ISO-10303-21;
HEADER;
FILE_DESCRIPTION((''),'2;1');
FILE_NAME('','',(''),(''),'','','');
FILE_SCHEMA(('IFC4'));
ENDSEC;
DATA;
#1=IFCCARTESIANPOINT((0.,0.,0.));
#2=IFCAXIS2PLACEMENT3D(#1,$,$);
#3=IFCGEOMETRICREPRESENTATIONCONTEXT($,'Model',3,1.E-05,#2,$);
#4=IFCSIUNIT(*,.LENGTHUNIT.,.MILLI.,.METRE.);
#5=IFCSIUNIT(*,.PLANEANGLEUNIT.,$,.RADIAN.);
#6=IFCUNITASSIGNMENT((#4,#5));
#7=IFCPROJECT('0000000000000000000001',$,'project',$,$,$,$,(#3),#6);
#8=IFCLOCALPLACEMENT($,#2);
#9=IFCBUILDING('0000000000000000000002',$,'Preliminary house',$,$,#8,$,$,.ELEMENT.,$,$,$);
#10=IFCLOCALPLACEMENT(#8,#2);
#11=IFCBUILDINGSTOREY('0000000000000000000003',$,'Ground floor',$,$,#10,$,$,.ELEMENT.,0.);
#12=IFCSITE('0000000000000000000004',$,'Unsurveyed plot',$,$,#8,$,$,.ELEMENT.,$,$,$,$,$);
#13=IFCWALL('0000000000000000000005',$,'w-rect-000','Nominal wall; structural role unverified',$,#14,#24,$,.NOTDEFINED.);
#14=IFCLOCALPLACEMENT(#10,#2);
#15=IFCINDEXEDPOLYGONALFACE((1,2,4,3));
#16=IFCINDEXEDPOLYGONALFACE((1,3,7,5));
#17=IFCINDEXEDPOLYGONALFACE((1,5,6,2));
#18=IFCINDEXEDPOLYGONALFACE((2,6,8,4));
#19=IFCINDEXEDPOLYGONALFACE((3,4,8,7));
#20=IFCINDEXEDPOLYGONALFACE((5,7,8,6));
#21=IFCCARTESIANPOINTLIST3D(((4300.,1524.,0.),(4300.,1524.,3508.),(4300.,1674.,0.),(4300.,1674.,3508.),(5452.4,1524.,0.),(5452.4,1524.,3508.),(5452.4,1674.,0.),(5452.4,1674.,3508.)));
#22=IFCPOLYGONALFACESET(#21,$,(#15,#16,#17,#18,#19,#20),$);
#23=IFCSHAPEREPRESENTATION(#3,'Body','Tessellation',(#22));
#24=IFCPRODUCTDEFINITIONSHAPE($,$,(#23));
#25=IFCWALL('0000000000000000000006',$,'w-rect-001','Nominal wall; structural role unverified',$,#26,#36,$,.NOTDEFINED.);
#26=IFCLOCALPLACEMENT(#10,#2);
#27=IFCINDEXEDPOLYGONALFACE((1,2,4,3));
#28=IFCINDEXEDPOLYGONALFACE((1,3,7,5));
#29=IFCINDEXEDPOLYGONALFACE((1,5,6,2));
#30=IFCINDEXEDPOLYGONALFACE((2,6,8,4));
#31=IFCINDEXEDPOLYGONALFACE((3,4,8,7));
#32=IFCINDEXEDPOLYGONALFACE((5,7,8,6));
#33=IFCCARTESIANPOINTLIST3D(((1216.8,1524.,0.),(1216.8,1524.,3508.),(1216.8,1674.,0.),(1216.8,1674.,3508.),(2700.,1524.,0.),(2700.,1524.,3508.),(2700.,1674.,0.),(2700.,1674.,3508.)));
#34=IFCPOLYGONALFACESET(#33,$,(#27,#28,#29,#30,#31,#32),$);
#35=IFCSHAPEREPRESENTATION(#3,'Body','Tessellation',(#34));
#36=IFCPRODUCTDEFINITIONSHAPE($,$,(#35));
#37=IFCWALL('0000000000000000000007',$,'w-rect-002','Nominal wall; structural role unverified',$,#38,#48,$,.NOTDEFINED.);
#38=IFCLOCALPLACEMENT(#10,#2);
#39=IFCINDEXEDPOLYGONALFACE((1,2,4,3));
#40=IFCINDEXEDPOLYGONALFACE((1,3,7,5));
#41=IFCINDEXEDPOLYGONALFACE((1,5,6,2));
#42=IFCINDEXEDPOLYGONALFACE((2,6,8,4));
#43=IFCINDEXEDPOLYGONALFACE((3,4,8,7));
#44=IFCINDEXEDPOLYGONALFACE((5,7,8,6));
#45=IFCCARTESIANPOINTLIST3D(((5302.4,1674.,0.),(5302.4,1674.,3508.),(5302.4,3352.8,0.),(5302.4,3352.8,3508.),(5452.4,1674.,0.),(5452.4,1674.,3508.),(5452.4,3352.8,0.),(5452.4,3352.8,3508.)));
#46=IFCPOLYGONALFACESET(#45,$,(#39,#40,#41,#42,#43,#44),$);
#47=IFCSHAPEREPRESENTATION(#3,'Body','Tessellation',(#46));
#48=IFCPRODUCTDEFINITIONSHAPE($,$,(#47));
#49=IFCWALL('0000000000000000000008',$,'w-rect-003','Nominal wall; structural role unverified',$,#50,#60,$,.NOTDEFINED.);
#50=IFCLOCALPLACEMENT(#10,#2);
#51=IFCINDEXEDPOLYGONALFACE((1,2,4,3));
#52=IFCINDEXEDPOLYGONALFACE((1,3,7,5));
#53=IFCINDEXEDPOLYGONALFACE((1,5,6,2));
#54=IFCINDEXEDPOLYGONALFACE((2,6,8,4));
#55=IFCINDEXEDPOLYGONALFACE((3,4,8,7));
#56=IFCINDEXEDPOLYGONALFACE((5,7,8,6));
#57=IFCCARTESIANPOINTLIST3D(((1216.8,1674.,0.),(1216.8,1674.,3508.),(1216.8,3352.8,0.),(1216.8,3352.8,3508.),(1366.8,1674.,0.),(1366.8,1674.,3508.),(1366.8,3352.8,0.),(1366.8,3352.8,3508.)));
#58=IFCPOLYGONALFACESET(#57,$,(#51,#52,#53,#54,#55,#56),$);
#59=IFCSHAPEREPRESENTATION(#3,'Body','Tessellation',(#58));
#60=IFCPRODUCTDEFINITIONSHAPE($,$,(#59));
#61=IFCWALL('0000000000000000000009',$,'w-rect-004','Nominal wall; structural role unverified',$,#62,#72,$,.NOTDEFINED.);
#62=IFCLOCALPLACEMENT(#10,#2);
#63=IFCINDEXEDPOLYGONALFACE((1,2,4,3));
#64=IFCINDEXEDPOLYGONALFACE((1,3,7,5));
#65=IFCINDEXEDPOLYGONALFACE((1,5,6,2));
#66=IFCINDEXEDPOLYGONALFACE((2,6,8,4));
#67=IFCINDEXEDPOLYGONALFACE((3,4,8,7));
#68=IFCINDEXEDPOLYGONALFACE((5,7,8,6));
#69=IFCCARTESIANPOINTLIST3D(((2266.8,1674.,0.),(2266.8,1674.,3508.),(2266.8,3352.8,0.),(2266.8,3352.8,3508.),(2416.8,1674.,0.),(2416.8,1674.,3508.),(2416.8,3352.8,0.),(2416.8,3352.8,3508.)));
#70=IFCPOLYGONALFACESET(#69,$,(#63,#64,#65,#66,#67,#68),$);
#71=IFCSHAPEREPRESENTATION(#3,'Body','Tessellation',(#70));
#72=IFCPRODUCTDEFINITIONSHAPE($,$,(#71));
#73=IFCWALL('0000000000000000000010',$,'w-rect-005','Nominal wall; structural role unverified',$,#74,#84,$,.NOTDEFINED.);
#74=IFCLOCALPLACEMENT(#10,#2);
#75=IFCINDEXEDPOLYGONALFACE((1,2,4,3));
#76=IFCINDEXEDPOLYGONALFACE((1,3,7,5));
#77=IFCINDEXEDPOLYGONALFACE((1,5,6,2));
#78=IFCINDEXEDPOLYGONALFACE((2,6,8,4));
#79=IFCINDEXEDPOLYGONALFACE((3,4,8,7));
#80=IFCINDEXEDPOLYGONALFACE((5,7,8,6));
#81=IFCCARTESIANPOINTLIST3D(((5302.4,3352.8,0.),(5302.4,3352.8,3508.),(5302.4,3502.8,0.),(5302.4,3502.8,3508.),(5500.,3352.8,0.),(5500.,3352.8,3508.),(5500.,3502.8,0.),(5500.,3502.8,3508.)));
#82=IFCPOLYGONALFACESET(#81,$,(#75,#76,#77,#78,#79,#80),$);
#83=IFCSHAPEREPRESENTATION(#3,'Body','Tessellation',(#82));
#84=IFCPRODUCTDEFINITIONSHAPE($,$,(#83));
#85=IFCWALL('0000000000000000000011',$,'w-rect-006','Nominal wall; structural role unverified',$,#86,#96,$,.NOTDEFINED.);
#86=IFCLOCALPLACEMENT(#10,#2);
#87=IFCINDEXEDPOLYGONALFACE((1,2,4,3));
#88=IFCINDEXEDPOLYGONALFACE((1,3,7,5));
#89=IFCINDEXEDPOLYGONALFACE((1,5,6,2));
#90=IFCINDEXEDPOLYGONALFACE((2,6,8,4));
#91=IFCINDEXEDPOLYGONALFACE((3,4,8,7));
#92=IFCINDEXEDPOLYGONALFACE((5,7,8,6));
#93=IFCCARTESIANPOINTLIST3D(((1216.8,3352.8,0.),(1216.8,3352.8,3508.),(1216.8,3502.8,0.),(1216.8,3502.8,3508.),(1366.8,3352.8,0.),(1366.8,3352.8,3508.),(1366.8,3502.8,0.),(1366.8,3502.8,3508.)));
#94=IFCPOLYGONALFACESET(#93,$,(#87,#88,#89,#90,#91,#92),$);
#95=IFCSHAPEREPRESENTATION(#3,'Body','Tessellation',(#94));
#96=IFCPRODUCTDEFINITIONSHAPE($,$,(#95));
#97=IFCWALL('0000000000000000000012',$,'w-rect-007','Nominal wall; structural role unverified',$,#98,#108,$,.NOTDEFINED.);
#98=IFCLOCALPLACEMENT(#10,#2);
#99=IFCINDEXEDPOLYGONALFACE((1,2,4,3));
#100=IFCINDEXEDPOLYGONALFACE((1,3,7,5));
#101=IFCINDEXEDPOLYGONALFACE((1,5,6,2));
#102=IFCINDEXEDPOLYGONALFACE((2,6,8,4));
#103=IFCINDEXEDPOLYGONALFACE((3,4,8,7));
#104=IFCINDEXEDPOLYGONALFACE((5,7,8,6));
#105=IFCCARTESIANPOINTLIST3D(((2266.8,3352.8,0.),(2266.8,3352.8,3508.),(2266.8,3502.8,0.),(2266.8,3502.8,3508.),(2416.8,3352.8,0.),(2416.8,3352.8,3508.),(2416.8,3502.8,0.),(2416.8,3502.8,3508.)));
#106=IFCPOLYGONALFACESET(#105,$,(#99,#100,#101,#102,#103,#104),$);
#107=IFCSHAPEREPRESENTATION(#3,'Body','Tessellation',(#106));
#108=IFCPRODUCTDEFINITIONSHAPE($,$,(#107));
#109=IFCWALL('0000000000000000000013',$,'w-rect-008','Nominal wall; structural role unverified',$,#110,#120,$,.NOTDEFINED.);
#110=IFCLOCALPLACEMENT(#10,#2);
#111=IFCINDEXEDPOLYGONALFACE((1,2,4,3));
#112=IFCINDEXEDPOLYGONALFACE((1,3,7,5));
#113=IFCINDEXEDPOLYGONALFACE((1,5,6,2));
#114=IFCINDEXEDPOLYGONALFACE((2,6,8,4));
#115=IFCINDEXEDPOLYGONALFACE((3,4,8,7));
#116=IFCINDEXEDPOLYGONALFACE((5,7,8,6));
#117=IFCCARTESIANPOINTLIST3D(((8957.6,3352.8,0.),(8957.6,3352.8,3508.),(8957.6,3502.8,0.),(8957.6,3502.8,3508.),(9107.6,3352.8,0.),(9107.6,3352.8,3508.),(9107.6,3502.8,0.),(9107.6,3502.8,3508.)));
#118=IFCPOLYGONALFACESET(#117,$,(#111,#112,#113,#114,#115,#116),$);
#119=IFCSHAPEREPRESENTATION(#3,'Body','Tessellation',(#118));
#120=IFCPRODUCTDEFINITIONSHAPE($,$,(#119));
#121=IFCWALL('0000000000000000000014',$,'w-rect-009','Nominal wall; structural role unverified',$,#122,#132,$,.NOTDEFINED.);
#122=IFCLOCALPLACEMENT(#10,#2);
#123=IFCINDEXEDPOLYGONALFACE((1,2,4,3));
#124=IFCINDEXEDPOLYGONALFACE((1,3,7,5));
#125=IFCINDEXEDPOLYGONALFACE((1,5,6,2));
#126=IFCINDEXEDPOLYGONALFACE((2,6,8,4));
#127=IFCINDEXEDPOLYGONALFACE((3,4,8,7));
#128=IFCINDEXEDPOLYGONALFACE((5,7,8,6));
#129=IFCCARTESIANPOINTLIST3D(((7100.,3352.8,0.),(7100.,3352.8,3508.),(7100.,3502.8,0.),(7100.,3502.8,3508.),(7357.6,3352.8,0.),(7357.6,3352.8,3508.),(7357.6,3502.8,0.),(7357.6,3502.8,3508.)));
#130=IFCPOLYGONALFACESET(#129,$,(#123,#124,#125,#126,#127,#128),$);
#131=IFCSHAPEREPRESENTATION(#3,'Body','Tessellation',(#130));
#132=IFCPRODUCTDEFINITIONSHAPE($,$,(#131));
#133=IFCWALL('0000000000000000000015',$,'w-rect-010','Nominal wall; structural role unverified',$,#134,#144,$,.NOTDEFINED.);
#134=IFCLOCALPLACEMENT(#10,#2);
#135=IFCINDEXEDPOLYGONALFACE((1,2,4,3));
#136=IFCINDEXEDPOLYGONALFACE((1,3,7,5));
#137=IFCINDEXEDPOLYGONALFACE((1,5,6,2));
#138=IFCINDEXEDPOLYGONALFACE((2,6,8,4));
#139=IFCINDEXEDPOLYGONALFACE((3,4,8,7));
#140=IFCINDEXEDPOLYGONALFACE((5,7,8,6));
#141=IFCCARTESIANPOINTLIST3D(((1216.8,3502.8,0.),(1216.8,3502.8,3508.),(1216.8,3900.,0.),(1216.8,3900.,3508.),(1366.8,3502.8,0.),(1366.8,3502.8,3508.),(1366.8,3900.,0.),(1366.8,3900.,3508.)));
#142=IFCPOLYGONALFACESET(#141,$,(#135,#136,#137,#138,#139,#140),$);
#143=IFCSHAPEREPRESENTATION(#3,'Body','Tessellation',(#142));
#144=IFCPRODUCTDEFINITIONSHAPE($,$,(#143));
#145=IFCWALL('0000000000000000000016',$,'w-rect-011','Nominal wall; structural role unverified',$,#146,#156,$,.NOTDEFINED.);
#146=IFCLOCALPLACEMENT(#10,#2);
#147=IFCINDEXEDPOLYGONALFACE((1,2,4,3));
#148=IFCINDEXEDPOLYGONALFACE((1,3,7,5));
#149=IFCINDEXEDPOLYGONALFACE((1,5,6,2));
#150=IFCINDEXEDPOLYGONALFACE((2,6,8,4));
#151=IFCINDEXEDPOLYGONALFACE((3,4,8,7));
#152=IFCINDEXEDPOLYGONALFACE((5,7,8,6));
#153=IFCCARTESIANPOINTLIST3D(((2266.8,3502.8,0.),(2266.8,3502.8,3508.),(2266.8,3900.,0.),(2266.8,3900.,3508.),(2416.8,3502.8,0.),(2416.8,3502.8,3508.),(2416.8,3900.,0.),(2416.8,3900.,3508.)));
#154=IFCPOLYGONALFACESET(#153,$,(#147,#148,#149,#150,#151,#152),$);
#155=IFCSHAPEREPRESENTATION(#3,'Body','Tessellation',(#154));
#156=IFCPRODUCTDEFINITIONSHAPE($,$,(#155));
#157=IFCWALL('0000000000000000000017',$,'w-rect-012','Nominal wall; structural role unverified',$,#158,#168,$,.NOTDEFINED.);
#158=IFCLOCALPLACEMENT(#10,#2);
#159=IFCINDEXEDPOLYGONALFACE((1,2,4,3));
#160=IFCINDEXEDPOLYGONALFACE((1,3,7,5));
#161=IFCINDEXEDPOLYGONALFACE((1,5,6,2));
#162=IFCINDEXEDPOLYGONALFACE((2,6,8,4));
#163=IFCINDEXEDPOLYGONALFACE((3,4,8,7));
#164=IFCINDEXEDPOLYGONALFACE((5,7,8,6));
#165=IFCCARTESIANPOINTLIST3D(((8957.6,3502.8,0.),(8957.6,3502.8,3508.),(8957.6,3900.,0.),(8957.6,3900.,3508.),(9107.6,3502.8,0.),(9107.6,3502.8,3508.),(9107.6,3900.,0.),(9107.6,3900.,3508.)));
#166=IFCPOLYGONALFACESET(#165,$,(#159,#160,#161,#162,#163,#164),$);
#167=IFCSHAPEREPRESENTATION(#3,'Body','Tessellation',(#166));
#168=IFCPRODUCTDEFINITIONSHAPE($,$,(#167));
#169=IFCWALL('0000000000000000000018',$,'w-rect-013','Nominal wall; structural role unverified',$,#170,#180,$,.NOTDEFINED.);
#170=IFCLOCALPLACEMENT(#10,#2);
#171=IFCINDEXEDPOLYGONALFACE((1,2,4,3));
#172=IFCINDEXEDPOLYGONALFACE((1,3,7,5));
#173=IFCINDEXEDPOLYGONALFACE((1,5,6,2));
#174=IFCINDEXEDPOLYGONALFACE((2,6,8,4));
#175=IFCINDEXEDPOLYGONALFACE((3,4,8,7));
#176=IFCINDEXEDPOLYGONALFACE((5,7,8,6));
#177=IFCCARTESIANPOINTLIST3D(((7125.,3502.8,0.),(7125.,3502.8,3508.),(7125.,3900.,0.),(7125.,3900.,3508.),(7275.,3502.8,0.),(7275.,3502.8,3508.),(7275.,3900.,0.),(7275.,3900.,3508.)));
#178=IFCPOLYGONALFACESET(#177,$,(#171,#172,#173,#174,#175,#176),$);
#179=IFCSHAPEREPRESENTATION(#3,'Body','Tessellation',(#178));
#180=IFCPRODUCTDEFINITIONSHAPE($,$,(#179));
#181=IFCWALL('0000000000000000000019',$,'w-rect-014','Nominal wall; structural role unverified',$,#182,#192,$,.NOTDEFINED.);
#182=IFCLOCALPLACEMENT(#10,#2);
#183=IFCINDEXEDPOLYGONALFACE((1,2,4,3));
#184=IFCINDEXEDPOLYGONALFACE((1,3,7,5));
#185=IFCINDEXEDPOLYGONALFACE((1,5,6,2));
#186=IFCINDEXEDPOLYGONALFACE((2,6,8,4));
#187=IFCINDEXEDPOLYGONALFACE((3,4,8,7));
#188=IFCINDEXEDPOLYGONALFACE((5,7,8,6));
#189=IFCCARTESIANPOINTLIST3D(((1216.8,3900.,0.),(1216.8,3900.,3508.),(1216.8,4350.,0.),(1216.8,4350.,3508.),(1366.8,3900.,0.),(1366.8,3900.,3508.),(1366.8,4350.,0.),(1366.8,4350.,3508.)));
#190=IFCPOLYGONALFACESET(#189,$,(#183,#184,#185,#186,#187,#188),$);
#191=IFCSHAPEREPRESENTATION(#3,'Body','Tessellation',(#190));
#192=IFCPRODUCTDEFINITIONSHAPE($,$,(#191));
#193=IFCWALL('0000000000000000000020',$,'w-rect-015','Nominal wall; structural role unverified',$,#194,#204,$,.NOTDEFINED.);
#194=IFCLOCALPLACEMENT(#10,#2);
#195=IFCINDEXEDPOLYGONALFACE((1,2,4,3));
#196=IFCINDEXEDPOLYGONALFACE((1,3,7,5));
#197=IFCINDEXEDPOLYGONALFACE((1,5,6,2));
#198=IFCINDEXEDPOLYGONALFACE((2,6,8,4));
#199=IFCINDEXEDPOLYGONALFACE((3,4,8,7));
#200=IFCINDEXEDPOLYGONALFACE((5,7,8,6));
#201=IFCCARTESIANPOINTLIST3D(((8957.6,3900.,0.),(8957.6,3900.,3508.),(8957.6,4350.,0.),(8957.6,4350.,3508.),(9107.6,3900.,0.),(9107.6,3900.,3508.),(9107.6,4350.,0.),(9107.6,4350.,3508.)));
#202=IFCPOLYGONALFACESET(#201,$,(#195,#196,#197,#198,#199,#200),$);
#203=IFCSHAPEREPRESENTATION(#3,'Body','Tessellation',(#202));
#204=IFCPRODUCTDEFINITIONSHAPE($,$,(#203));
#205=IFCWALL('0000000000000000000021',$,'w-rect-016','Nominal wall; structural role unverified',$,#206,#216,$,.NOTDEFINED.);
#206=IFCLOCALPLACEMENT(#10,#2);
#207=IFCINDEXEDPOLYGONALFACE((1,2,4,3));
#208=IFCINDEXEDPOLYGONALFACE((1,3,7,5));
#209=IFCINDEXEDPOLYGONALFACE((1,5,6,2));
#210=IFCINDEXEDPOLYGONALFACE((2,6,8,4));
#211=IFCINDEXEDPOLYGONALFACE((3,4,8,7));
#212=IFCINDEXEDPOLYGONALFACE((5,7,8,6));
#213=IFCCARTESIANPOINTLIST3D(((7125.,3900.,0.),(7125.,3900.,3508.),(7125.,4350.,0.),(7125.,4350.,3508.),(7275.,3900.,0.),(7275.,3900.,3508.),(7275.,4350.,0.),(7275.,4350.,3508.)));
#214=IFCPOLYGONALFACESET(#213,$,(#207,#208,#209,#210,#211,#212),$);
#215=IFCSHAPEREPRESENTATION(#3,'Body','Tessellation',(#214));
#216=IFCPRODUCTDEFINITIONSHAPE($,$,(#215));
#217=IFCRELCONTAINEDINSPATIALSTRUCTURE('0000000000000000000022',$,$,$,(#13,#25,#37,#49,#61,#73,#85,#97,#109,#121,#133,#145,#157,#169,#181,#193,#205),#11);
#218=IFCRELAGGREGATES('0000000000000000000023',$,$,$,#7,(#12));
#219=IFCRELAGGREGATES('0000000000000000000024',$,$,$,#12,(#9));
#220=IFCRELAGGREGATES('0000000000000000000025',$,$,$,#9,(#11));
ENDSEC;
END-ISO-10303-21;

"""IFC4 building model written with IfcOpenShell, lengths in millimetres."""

from ifc_helpers import new_model, si_unit, origin, place, context, project, spatial, polyline, outline, extrude, element, save


model = new_model("IFC4")

# Units and contexts
model_context = context("Model", 3, precision=1e-05, world=origin())
ifc_project = project(units=[si_unit("LENGTHUNIT", "METRE", prefix="MILLI"), si_unit("PLANEANGLEUNIT", "RADIAN")], contexts=[model_context])

# Site, building, storey
placement_1 = place(None, origin())
site = spatial("IfcSite", under=ifc_project, at=placement_1, Name="Unsurveyed plot", CompositionType="ELEMENT")
building = spatial("IfcBuilding", under=site, at=placement_1, Name="Preliminary house", CompositionType="ELEMENT")
placement_2 = place(placement_1, origin())
storey = spatial("IfcBuildingStorey", under=building, at=placement_2, Name="Ground floor", CompositionType="ELEMENT", Elevation=0.0)

# Walls
element("IfcWall", 1, at=placement_2, inside=storey, Name="w-rect-000", Description="Nominal wall; structural role unverified", PredefinedType="NOTDEFINED", context=model_context, shape_type="SweptSolid", body=[
    extrude(outline(polyline([(4300.0, 1524.0), (5452.4, 1524.0), (5452.4, 1674.0), (4300.0, 1674.0), (4300.0, 1524.0)])), origin(), (0.0, 0.0, 1.0), 3508.0),
])
element("IfcWall", 2, at=placement_2, inside=storey, Name="w-rect-001", Description="Nominal wall; structural role unverified", PredefinedType="NOTDEFINED", context=model_context, shape_type="SweptSolid", body=[
    extrude(outline(polyline([(1216.8, 1524.0), (2700.0, 1524.0), (2700.0, 1674.0), (1216.8, 1674.0), (1216.8, 1524.0)])), origin(), (0.0, 0.0, 1.0), 3508.0),
])
element("IfcWall", 3, at=placement_2, inside=storey, Name="w-rect-002", Description="Nominal wall; structural role unverified", PredefinedType="NOTDEFINED", context=model_context, shape_type="SweptSolid", body=[
    extrude(outline(polyline([(5302.4, 1674.0), (5452.4, 1674.0), (5452.4, 3352.8), (5302.4, 3352.8), (5302.4, 1674.0)])), origin(), (0.0, 0.0, 1.0), 3508.0),
])
element("IfcWall", 4, at=placement_2, inside=storey, Name="w-rect-003", Description="Nominal wall; structural role unverified", PredefinedType="NOTDEFINED", context=model_context, shape_type="SweptSolid", body=[
    extrude(outline(polyline([(1216.8, 1674.0), (1366.8, 1674.0), (1366.8, 3352.8), (1216.8, 3352.8), (1216.8, 1674.0)])), origin(), (0.0, 0.0, 1.0), 3508.0),
])
element("IfcWall", 5, at=placement_2, inside=storey, Name="w-rect-004", Description="Nominal wall; structural role unverified", PredefinedType="NOTDEFINED", context=model_context, shape_type="SweptSolid", body=[
    extrude(outline(polyline([(2266.8, 1674.0), (2416.8, 1674.0), (2416.8, 3352.8), (2266.8, 3352.8), (2266.8, 1674.0)])), origin(), (0.0, 0.0, 1.0), 3508.0),
])
element("IfcWall", 6, at=placement_2, inside=storey, Name="w-rect-005", Description="Nominal wall; structural role unverified", PredefinedType="NOTDEFINED", context=model_context, shape_type="SweptSolid", body=[
    extrude(outline(polyline([(5302.4, 3352.8), (5500.0, 3352.8), (5500.0, 3502.8), (5302.4, 3502.8), (5302.4, 3352.8)])), origin(), (0.0, 0.0, 1.0), 3508.0),
])
element("IfcWall", 7, at=placement_2, inside=storey, Name="w-rect-006", Description="Nominal wall; structural role unverified", PredefinedType="NOTDEFINED", context=model_context, shape_type="SweptSolid", body=[
    extrude(outline(polyline([(1216.8, 3352.8), (1366.8, 3352.8), (1366.8, 3502.8), (1216.8, 3502.8), (1216.8, 3352.8)])), origin(), (0.0, 0.0, 1.0), 3508.0),
])
element("IfcWall", 8, at=placement_2, inside=storey, Name="w-rect-007", Description="Nominal wall; structural role unverified", PredefinedType="NOTDEFINED", context=model_context, shape_type="SweptSolid", body=[
    extrude(outline(polyline([(2266.8, 3352.8), (2416.8, 3352.8), (2416.8, 3502.8), (2266.8, 3502.8), (2266.8, 3352.8)])), origin(), (0.0, 0.0, 1.0), 3508.0),
])
element("IfcWall", 9, at=placement_2, inside=storey, Name="w-rect-008", Description="Nominal wall; structural role unverified", PredefinedType="NOTDEFINED", context=model_context, shape_type="SweptSolid", body=[
    extrude(outline(polyline([(8957.6, 3352.8), (9107.6, 3352.8), (9107.6, 3502.8), (8957.6, 3502.8), (8957.6, 3352.8)])), origin(), (0.0, 0.0, 1.0), 3508.0),
])
element("IfcWall", 10, at=placement_2, inside=storey, Name="w-rect-009", Description="Nominal wall; structural role unverified", PredefinedType="NOTDEFINED", context=model_context, shape_type="SweptSolid", body=[
    extrude(outline(polyline([(7100.0, 3352.8), (7357.6, 3352.8), (7357.6, 3502.8), (7100.0, 3502.8), (7100.0, 3352.8)])), origin(), (0.0, 0.0, 1.0), 3508.0),
])
element("IfcWall", 11, at=placement_2, inside=storey, Name="w-rect-010", Description="Nominal wall; structural role unverified", PredefinedType="NOTDEFINED", context=model_context, shape_type="SweptSolid", body=[
    extrude(outline(polyline([(1216.8, 3502.8), (1366.8, 3502.8), (1366.8, 3900.0), (1216.8, 3900.0), (1216.8, 3502.8)])), origin(), (0.0, 0.0, 1.0), 3508.0),
])
element("IfcWall", 12, at=placement_2, inside=storey, Name="w-rect-011", Description="Nominal wall; structural role unverified", PredefinedType="NOTDEFINED", context=model_context, shape_type="SweptSolid", body=[
    extrude(outline(polyline([(2266.8, 3502.8), (2416.8, 3502.8), (2416.8, 3900.0), (2266.8, 3900.0), (2266.8, 3502.8)])), origin(), (0.0, 0.0, 1.0), 3508.0),
])
element("IfcWall", 13, at=placement_2, inside=storey, Name="w-rect-012", Description="Nominal wall; structural role unverified", PredefinedType="NOTDEFINED", context=model_context, shape_type="SweptSolid", body=[
    extrude(outline(polyline([(8957.6, 3502.8), (9107.6, 3502.8), (9107.6, 3900.0), (8957.6, 3900.0), (8957.6, 3502.8)])), origin(), (0.0, 0.0, 1.0), 3508.0),
])
element("IfcWall", 14, at=placement_2, inside=storey, Name="w-rect-013", Description="Nominal wall; structural role unverified", PredefinedType="NOTDEFINED", context=model_context, shape_type="SweptSolid", body=[
    extrude(outline(polyline([(7125.0, 3502.8), (7275.0, 3502.8), (7275.0, 3900.0), (7125.0, 3900.0), (7125.0, 3502.8)])), origin(), (0.0, 0.0, 1.0), 3508.0),
])
element("IfcWall", 15, at=placement_2, inside=storey, Name="w-rect-014", Description="Nominal wall; structural role unverified", PredefinedType="NOTDEFINED", context=model_context, shape_type="SweptSolid", body=[
    extrude(outline(polyline([(1216.8, 3900.0), (1366.8, 3900.0), (1366.8, 4350.0), (1216.8, 4350.0), (1216.8, 3900.0)])), origin(), (0.0, 0.0, 1.0), 3508.0),
])
element("IfcWall", 16, at=placement_2, inside=storey, Name="w-rect-015", Description="Nominal wall; structural role unverified", PredefinedType="NOTDEFINED", context=model_context, shape_type="SweptSolid", body=[
    extrude(outline(polyline([(8957.6, 3900.0), (9107.6, 3900.0), (9107.6, 4350.0), (8957.6, 4350.0), (8957.6, 3900.0)])), origin(), (0.0, 0.0, 1.0), 3508.0),
])
element("IfcWall", 17, at=placement_2, inside=storey, Name="w-rect-016", Description="Nominal wall; structural role unverified", PredefinedType="NOTDEFINED", context=model_context, shape_type="SweptSolid", body=[
    extrude(outline(polyline([(7125.0, 3900.0), (7275.0, 3900.0), (7275.0, 4350.0), (7125.0, 4350.0), (7125.0, 3900.0)])), origin(), (0.0, 0.0, 1.0), 3508.0),
])

save(model, "model.ifc")
